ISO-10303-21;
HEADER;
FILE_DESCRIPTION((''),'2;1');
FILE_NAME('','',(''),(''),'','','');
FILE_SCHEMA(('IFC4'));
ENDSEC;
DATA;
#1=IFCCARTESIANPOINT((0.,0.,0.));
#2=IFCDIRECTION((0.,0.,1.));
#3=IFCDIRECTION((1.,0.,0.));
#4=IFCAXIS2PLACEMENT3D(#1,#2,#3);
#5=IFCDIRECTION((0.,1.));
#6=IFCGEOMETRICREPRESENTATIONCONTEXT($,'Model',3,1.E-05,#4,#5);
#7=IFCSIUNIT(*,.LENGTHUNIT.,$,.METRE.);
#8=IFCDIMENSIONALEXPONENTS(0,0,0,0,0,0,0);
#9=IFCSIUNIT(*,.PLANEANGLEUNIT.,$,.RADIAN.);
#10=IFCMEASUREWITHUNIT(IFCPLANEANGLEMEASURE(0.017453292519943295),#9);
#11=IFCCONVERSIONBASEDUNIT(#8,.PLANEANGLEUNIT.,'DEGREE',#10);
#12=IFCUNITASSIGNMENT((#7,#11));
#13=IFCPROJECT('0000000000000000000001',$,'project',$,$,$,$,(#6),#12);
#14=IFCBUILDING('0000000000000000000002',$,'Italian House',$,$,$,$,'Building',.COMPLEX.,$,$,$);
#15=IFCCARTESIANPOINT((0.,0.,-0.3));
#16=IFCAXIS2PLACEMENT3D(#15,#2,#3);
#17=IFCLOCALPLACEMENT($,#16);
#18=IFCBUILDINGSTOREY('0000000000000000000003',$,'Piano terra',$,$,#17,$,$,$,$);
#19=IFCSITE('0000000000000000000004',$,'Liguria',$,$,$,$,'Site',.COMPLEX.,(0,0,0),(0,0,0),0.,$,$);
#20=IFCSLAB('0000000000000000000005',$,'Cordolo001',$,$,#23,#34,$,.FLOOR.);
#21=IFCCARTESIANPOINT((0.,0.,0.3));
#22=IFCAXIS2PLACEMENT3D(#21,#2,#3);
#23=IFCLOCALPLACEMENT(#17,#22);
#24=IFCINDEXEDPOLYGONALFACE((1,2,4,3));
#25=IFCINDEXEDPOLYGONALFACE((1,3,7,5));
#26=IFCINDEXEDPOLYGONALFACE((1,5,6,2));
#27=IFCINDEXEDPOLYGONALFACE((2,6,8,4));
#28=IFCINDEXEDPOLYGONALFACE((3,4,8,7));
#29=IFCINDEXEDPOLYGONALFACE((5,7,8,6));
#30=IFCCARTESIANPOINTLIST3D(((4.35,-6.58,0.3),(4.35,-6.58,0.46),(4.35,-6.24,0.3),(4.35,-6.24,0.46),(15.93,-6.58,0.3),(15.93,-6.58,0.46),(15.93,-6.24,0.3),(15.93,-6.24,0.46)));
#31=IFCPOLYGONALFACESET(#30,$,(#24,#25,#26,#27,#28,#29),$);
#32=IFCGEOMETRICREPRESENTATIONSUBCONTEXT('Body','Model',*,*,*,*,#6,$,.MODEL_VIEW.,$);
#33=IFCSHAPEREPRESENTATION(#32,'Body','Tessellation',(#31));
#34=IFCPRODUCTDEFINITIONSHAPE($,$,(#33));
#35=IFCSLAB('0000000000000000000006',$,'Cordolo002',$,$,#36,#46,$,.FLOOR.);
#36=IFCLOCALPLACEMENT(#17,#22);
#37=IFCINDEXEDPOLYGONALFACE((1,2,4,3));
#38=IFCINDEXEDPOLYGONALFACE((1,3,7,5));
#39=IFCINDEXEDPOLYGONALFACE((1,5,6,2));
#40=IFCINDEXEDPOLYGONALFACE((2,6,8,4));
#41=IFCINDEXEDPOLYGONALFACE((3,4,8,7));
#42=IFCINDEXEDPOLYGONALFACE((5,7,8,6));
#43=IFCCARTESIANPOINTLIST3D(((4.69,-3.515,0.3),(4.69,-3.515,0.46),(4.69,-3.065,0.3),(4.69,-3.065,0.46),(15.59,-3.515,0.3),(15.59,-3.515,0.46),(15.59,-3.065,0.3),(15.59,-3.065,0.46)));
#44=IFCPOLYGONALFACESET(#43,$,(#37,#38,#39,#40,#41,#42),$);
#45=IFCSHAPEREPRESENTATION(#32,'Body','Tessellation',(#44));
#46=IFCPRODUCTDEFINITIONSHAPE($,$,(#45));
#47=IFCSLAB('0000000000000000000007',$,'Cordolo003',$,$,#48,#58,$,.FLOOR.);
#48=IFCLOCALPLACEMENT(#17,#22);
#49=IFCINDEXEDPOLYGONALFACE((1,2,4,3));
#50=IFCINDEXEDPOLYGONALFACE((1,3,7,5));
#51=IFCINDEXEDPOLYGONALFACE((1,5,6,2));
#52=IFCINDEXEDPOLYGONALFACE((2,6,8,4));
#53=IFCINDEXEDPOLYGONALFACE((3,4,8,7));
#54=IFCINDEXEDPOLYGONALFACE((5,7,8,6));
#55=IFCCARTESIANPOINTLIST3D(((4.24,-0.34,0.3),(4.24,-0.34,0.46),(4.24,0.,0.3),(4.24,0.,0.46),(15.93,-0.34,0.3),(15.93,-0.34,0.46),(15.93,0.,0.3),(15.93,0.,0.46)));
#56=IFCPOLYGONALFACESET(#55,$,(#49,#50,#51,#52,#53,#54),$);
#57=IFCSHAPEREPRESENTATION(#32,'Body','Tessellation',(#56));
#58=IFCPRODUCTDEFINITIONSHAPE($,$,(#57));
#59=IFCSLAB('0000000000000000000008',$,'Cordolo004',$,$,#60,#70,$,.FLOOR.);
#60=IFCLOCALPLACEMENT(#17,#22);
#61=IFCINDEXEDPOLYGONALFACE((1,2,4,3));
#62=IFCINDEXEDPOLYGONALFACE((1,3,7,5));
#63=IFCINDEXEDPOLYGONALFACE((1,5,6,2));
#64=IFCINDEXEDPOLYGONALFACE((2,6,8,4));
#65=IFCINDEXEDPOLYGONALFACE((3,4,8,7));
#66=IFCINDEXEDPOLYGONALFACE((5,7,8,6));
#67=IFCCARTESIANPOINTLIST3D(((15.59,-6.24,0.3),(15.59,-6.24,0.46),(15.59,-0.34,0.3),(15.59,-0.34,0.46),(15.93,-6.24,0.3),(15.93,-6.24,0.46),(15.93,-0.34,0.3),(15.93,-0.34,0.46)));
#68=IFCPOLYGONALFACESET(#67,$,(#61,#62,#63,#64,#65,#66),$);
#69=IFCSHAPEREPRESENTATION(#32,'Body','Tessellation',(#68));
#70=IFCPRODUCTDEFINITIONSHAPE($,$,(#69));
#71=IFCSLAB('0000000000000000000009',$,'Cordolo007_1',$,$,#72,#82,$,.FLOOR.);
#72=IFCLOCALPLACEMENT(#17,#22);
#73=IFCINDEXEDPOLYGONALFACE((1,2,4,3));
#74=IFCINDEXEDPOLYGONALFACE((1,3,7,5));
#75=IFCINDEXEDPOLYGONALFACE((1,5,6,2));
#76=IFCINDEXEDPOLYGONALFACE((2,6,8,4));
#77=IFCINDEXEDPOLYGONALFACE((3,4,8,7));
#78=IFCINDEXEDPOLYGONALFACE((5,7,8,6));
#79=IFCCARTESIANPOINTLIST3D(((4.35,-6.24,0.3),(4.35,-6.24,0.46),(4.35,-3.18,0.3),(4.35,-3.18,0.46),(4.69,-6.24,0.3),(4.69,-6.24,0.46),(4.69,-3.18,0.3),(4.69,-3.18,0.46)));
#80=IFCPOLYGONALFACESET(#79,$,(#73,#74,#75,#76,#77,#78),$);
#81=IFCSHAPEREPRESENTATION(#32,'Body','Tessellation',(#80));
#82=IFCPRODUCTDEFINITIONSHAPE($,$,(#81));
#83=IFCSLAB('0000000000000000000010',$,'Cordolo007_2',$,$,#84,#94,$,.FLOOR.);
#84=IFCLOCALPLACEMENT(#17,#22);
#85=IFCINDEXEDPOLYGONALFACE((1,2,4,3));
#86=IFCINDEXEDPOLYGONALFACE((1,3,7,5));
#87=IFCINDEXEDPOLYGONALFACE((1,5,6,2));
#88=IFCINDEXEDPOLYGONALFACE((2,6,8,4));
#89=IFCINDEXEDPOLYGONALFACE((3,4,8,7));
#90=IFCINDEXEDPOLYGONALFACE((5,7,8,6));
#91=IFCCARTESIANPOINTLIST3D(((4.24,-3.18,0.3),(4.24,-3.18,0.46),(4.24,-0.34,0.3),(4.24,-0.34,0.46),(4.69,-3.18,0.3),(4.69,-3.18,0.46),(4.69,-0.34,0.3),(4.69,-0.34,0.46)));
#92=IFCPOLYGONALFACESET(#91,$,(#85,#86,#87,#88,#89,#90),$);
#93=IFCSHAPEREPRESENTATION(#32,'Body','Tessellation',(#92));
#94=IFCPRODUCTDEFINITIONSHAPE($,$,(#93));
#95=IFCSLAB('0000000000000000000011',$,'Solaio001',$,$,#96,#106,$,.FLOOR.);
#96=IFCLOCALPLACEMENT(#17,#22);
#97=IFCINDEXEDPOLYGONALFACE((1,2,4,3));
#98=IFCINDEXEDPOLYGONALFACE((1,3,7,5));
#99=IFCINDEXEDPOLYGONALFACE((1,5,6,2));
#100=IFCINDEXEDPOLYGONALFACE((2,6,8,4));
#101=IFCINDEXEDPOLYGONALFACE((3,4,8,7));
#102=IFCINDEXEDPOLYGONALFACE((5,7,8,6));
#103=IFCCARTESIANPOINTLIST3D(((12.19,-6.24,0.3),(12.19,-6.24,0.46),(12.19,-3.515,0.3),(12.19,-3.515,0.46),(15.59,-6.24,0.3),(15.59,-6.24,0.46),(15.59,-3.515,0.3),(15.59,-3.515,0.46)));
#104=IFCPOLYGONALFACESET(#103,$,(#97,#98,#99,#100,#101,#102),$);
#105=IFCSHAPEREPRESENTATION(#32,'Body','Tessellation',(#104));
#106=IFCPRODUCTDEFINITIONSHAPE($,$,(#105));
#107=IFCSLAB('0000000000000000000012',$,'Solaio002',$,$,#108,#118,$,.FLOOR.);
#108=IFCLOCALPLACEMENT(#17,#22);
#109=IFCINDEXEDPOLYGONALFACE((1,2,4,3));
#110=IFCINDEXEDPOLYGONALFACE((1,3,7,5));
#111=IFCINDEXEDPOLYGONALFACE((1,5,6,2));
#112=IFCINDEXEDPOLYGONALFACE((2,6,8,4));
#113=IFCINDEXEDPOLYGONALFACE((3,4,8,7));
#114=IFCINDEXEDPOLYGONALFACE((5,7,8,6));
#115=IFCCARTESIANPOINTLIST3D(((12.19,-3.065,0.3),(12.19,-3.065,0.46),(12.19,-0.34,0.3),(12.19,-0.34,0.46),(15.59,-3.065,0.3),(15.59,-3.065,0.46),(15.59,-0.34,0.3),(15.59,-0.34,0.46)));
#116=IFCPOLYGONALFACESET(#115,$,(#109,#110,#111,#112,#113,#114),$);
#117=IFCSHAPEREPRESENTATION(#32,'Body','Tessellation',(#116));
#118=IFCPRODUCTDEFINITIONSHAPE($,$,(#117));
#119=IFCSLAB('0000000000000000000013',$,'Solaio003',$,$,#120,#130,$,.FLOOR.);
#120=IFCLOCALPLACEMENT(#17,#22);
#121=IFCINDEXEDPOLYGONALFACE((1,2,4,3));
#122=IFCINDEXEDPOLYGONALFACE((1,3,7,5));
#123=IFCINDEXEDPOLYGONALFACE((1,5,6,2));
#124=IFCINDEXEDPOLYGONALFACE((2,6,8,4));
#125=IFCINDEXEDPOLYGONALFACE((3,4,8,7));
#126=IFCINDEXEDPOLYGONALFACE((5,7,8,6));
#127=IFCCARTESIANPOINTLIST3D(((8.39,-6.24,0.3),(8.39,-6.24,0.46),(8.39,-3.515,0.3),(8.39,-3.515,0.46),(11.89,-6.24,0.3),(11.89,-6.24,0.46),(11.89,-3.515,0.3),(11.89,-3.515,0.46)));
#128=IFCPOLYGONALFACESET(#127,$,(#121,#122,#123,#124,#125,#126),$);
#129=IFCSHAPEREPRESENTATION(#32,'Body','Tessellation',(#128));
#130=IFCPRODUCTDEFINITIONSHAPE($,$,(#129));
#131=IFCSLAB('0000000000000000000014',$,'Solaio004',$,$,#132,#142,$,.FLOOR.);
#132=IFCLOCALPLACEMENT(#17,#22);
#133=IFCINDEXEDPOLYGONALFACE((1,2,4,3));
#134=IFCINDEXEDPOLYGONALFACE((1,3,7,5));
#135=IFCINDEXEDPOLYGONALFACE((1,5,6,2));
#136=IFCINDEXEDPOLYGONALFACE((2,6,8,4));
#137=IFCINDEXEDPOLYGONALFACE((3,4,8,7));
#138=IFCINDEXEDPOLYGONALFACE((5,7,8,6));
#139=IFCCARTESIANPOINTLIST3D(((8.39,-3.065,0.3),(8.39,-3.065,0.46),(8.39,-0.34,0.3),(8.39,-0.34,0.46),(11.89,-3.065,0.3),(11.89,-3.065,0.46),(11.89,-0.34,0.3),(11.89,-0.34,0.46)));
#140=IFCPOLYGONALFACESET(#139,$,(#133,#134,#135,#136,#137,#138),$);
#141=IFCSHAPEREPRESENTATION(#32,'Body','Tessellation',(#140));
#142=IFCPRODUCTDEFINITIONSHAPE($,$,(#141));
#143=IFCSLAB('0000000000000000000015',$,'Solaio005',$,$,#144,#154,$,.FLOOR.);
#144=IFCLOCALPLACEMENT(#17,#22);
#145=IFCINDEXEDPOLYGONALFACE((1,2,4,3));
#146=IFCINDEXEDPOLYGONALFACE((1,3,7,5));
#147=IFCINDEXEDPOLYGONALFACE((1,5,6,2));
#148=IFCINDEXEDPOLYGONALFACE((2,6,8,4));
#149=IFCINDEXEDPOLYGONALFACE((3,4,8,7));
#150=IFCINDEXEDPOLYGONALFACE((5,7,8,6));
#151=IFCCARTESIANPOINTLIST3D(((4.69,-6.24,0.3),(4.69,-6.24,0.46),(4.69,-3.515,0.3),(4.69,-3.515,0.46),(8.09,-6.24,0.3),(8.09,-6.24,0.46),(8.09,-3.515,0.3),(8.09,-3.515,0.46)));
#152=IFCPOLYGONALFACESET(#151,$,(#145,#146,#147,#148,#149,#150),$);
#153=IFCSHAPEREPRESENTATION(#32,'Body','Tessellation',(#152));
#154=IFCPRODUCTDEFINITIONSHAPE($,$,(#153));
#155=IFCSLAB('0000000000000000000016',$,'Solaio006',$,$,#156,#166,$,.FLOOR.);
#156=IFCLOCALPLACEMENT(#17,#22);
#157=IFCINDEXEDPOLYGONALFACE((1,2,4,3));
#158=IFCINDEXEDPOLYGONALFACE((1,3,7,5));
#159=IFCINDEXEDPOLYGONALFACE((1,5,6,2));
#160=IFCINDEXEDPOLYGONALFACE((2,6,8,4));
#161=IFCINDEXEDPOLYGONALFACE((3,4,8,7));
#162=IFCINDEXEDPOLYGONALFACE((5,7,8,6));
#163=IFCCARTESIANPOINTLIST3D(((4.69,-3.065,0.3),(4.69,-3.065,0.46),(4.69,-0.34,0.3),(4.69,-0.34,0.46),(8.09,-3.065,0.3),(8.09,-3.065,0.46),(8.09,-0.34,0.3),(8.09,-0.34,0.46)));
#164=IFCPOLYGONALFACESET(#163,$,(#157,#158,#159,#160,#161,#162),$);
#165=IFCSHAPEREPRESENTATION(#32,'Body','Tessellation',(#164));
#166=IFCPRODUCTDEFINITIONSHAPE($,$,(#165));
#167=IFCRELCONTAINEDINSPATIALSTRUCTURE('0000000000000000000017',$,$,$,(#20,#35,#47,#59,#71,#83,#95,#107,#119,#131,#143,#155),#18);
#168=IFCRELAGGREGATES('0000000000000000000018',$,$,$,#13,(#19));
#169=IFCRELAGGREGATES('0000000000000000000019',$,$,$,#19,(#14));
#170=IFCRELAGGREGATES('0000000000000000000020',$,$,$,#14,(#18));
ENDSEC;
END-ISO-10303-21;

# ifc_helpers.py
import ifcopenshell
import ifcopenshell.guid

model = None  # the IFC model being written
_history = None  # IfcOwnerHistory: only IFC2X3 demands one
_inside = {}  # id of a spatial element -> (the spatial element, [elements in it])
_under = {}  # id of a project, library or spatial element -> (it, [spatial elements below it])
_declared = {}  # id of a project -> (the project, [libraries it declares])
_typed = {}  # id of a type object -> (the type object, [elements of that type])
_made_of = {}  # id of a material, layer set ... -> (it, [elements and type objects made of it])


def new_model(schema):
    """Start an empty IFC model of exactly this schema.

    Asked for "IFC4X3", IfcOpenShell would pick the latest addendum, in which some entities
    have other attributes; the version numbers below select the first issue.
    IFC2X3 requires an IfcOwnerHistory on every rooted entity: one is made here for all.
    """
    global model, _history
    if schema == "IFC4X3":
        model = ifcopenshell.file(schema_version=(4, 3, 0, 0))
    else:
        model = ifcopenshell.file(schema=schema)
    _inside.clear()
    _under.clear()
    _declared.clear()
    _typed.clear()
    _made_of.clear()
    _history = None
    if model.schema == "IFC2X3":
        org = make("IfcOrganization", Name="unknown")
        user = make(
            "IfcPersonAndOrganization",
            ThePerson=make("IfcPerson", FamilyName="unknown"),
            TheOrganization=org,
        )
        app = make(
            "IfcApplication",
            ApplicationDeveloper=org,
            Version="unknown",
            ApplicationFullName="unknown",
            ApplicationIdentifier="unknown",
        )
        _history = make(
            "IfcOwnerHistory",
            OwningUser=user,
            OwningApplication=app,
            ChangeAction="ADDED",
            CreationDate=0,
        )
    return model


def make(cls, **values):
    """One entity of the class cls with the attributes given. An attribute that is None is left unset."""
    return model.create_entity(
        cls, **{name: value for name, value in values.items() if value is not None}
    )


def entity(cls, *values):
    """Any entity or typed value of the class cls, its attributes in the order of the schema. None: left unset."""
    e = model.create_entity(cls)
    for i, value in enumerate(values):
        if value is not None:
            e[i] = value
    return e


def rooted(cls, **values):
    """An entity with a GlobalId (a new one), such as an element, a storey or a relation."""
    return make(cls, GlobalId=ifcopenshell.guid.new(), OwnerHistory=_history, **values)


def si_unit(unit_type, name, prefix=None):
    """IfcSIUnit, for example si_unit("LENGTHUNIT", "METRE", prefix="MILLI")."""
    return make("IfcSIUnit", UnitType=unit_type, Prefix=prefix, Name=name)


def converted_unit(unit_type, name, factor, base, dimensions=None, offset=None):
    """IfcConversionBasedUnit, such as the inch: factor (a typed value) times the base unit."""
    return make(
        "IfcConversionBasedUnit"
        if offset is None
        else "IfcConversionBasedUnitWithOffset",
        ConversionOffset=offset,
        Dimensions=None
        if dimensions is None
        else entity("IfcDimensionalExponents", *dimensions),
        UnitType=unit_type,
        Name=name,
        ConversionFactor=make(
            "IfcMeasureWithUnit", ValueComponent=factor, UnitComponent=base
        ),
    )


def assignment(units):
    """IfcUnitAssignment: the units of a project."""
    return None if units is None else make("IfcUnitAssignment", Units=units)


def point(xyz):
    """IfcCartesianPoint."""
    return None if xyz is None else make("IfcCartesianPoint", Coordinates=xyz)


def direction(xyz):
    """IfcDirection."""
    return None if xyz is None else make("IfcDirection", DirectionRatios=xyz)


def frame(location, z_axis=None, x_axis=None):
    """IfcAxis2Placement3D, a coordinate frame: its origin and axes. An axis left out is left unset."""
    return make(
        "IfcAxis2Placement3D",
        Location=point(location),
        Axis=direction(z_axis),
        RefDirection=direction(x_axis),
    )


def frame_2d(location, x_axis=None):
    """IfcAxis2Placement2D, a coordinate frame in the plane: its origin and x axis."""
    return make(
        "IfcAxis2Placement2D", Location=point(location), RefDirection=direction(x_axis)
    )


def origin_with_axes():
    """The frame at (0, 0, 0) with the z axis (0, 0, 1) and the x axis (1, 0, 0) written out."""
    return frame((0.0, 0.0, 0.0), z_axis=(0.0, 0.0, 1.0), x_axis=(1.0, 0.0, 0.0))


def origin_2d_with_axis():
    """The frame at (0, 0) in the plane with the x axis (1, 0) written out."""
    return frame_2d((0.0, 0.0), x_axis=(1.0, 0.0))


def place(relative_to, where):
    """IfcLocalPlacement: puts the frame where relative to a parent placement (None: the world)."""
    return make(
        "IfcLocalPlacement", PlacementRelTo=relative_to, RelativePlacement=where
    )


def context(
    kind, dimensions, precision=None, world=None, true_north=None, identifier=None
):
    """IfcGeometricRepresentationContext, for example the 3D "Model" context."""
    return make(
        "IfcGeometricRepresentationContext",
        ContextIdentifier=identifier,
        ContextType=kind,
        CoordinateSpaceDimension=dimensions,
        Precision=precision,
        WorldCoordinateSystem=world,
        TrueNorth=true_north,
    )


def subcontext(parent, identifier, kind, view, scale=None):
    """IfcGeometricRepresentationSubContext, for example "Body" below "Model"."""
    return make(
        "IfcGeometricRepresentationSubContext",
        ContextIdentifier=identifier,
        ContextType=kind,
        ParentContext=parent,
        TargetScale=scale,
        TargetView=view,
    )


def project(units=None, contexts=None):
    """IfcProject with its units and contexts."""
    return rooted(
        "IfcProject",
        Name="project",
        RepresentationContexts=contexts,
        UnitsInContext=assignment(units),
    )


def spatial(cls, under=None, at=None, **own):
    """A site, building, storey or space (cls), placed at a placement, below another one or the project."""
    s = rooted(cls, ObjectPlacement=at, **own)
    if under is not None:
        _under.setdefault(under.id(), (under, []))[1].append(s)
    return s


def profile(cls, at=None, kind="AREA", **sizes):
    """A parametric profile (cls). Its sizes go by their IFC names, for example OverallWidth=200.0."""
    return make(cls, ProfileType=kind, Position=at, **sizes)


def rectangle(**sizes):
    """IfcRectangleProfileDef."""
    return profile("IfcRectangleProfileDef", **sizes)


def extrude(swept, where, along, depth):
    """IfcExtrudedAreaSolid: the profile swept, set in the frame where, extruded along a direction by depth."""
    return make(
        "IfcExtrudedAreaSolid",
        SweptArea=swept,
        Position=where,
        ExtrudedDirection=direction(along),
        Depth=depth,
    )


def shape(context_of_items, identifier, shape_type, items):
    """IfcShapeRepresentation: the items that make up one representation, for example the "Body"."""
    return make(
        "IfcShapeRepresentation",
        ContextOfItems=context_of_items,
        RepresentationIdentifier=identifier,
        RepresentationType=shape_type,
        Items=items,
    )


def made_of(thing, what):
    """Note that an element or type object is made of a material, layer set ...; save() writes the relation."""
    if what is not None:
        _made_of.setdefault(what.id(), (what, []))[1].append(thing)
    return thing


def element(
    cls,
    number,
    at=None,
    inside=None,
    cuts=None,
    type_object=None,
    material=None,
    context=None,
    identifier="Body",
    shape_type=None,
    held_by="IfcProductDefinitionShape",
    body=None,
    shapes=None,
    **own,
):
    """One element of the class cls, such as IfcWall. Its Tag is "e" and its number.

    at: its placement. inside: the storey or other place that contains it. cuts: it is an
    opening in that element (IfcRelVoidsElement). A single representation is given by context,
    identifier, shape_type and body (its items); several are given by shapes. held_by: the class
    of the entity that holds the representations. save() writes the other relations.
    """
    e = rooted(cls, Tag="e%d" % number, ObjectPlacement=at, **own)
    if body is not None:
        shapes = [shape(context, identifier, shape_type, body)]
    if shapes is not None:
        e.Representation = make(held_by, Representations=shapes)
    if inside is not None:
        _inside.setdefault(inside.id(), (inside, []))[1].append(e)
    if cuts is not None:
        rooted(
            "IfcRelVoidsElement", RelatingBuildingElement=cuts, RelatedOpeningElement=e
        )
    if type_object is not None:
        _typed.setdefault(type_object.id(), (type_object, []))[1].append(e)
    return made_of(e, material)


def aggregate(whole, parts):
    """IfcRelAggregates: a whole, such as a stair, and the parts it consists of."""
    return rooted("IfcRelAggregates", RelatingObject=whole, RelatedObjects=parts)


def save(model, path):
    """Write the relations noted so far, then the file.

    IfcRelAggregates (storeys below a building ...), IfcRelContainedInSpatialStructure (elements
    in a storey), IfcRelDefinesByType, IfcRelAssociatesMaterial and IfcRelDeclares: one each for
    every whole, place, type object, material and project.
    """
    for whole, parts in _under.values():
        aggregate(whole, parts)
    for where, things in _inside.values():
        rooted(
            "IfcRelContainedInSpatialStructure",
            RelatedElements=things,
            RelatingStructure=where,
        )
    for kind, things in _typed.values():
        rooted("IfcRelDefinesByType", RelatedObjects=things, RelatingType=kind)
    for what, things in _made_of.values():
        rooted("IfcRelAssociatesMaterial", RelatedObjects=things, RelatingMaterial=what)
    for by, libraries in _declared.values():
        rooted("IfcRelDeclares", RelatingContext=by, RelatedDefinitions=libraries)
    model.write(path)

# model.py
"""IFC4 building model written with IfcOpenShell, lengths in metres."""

from ifc_helpers import new_model, entity, si_unit, converted_unit, direction, frame, frame_2d, origin_with_axes, origin_2d_with_axis, place, context, subcontext, project, spatial, rectangle, extrude, element, save


model = new_model("IFC4")

# Units and contexts
model_context = context("Model", 3, precision=1e-05, world=origin_with_axes(), true_north=direction((0.0, 1.0)))
body_context = subcontext(model_context, "Body", "Model", "MODEL_VIEW")
ifc_project = project(units=[si_unit("LENGTHUNIT", "METRE"), converted_unit("PLANEANGLEUNIT", "DEGREE", entity("IfcPlaneAngleMeasure", 0.017453292519943295), si_unit("PLANEANGLEUNIT", "RADIAN"), dimensions=[0, 0, 0, 0, 0, 0, 0])], contexts=[model_context])

# Site, building, storey
site = spatial("IfcSite", under=ifc_project, Name="Liguria", LongName="Site", CompositionType="COMPLEX", RefLatitude=(0, 0, 0), RefLongitude=(0, 0, 0), RefElevation=0.0)
building = spatial("IfcBuilding", under=site, Name="Italian House", LongName="Building", CompositionType="COMPLEX")
storey_placement = place(None, frame((0.0, 0.0, -0.3), z_axis=(0.0, 0.0, 1.0), x_axis=(1.0, 0.0, 0.0)))
storey = spatial("IfcBuildingStorey", under=building, at=storey_placement, Name="Piano terra")

# Slabs
slab_1_placement = place(storey_placement, frame((0.0, 0.0, 0.3), z_axis=(0.0, 0.0, 1.0), x_axis=(1.0, 0.0, 0.0)))
element("IfcSlab", 1, at=slab_1_placement, inside=storey, Name="Cordolo001", PredefinedType="FLOOR", context=body_context, shape_type="SweptSolid", body=[
    extrude(rectangle(XDim=11.58, YDim=0.34, at=origin_2d_with_axis()), frame((10.14, -6.41, 0.46), z_axis=(0.0, 0.0, 1.0), x_axis=(1.0, 0.0, 0.0)), (0.0, 0.0, -1.0), 0.16),
])
slab_2_placement = place(storey_placement, frame((0.0, 0.0, 0.3), z_axis=(0.0, 0.0, 1.0), x_axis=(1.0, 0.0, 0.0)))
element("IfcSlab", 2, at=slab_2_placement, inside=storey, Name="Cordolo002", PredefinedType="FLOOR", context=body_context, shape_type="SweptSolid", body=[
    extrude(rectangle(XDim=10.9, YDim=0.45, at=frame_2d((0.0, 0.0), x_axis=(1.0, 0.0))), frame((10.14, -3.29, 0.46), z_axis=(0.0, 0.0, 1.0), x_axis=(1.0, 0.0, 0.0)), (0.0, 0.0, -1.0), 0.16),
])
slab_3_placement = place(storey_placement, frame((0.0, 0.0, 0.3), z_axis=(0.0, 0.0, 1.0), x_axis=(1.0, 0.0, 0.0)))
element("IfcSlab", 3, at=slab_3_placement, inside=storey, Name="Cordolo003", PredefinedType="FLOOR", context=body_context, shape_type="SweptSolid", body=[
    extrude(rectangle(XDim=11.69, YDim=0.34, at=frame_2d((0.0, 0.0), x_axis=(1.0, 0.0))), frame((10.085, -0.17, 0.46), z_axis=(0.0, 0.0, 1.0), x_axis=(1.0, 0.0, 0.0)), (0.0, 0.0, -1.0), 0.16),
])
slab_4_placement = place(storey_placement, frame((0.0, 0.0, 0.3), z_axis=(0.0, 0.0, 1.0), x_axis=(1.0, 0.0, 0.0)))
element("IfcSlab", 4, at=slab_4_placement, inside=storey, Name="Cordolo004", PredefinedType="FLOOR", context=body_context, shape_type="SweptSolid", body=[
    extrude(rectangle(XDim=0.34, YDim=5.9, at=frame_2d((0.0, 0.0), x_axis=(1.0, 0.0))), frame((15.76, -3.29, 0.46), z_axis=(0.0, 0.0, 1.0), x_axis=(1.0, 0.0, 0.0)), (0.0, 0.0, -1.0), 0.16),
])
slab_5_placement = place(storey_placement, frame((0.0, 0.0, 0.3), z_axis=(0.0, 0.0, 1.0), x_axis=(1.0, 0.0, 0.0)))
element("IfcSlab", 5, at=slab_5_placement, inside=storey, Name="Cordolo007_1", PredefinedType="FLOOR", context=body_context, shape_type="SweptSolid", body=[
    extrude(rectangle(XDim=0.34, YDim=3.06, at=frame_2d((0.0, 0.0), x_axis=(1.0, 0.0))), frame((4.52, -4.71, 0.46), z_axis=(0.0, 0.0, 1.0), x_axis=(1.0, 0.0, 0.0)), (0.0, 0.0, -1.0), 0.16),
])
slab_6_placement = place(storey_placement, frame((0.0, 0.0, 0.3), z_axis=(0.0, 0.0, 1.0), x_axis=(1.0, 0.0, 0.0)))
element("IfcSlab", 6, at=slab_6_placement, inside=storey, Name="Cordolo007_2", PredefinedType="FLOOR", context=body_context, shape_type="SweptSolid", body=[
    extrude(rectangle(XDim=0.45, YDim=2.84, at=origin_2d_with_axis()), frame((4.465, -1.76, 0.46), z_axis=(0.0, 0.0, 1.0), x_axis=(1.0, 0.0, 0.0)), (0.0, 0.0, -1.0), 0.16),
])
slab_7_placement = place(storey_placement, frame((0.0, 0.0, 0.3), z_axis=(0.0, 0.0, 1.0), x_axis=(1.0, 0.0, 0.0)))
element("IfcSlab", 7, at=slab_7_placement, inside=storey, Name="Solaio001", PredefinedType="FLOOR", context=body_context, shape_type="SweptSolid", body=[
    extrude(rectangle(XDim=3.4, YDim=2.725, at=origin_2d_with_axis()), frame((13.89, -4.8775, 0.46), z_axis=(0.0, 0.0, 1.0), x_axis=(1.0, 0.0, 0.0)), (0.0, 0.0, -1.0), 0.16),
])
slab_8_placement = place(storey_placement, frame((0.0, 0.0, 0.3), z_axis=(0.0, 0.0, 1.0), x_axis=(1.0, 0.0, 0.0)))
element("IfcSlab", 8, at=slab_8_placement, inside=storey, Name="Solaio002", PredefinedType="FLOOR", context=body_context, shape_type="SweptSolid", body=[
    extrude(rectangle(XDim=3.4, YDim=2.725, at=origin_2d_with_axis()), frame((13.89, -1.7025, 0.46), z_axis=(0.0, 0.0, 1.0), x_axis=(1.0, 0.0, 0.0)), (0.0, 0.0, -1.0), 0.16),
])
slab_9_placement = place(storey_placement, frame((0.0, 0.0, 0.3), z_axis=(0.0, 0.0, 1.0), x_axis=(1.0, 0.0, 0.0)))
element("IfcSlab", 9, at=slab_9_placement, inside=storey, Name="Solaio003", PredefinedType="FLOOR", context=body_context, shape_type="SweptSolid", body=[
    extrude(rectangle(XDim=3.5, YDim=2.725, at=origin_2d_with_axis()), frame((10.14, -4.8775, 0.46), z_axis=(0.0, 0.0, 1.0), x_axis=(1.0, 0.0, 0.0)), (0.0, 0.0, -1.0), 0.16),
])
slab_10_placement = place(storey_placement, frame((0.0, 0.0, 0.3), z_axis=(0.0, 0.0, 1.0), x_axis=(1.0, 0.0, 0.0)))
element("IfcSlab", 10, at=slab_10_placement, inside=storey, Name="Solaio004", PredefinedType="FLOOR", context=body_context, shape_type="SweptSolid", body=[
    extrude(rectangle(XDim=3.5, YDim=2.725, at=origin_2d_with_axis()), frame((10.14, -1.7025, 0.46), z_axis=(0.0, 0.0, 1.0), x_axis=(1.0, 0.0, 0.0)), (0.0, 0.0, -1.0), 0.16),
])
slab_11_placement = place(storey_placement, frame((0.0, 0.0, 0.3), z_axis=(0.0, 0.0, 1.0), x_axis=(1.0, 0.0, 0.0)))
element("IfcSlab", 11, at=slab_11_placement, inside=storey, Name="Solaio005", PredefinedType="FLOOR", context=body_context, shape_type="SweptSolid", body=[
    extrude(rectangle(XDim=3.4, YDim=2.725, at=origin_2d_with_axis()), frame((6.39, -4.8775, 0.46), z_axis=(0.0, 0.0, 1.0), x_axis=(1.0, 0.0, 0.0)), (0.0, 0.0, -1.0), 0.16),
])
slab_12_placement = place(storey_placement, frame((0.0, 0.0, 0.3), z_axis=(0.0, 0.0, 1.0), x_axis=(1.0, 0.0, 0.0)))
element("IfcSlab", 12, at=slab_12_placement, inside=storey, Name="Solaio006", PredefinedType="FLOOR", context=body_context, shape_type="SweptSolid", body=[
    extrude(rectangle(XDim=3.4, YDim=2.725, at=origin_2d_with_axis()), frame((6.39, -1.7025, 0.46), z_axis=(0.0, 0.0, 1.0), x_axis=(1.0, 0.0, 0.0)), (0.0, 0.0, -1.0), 0.16),
])

save(model, "model.ifc")
